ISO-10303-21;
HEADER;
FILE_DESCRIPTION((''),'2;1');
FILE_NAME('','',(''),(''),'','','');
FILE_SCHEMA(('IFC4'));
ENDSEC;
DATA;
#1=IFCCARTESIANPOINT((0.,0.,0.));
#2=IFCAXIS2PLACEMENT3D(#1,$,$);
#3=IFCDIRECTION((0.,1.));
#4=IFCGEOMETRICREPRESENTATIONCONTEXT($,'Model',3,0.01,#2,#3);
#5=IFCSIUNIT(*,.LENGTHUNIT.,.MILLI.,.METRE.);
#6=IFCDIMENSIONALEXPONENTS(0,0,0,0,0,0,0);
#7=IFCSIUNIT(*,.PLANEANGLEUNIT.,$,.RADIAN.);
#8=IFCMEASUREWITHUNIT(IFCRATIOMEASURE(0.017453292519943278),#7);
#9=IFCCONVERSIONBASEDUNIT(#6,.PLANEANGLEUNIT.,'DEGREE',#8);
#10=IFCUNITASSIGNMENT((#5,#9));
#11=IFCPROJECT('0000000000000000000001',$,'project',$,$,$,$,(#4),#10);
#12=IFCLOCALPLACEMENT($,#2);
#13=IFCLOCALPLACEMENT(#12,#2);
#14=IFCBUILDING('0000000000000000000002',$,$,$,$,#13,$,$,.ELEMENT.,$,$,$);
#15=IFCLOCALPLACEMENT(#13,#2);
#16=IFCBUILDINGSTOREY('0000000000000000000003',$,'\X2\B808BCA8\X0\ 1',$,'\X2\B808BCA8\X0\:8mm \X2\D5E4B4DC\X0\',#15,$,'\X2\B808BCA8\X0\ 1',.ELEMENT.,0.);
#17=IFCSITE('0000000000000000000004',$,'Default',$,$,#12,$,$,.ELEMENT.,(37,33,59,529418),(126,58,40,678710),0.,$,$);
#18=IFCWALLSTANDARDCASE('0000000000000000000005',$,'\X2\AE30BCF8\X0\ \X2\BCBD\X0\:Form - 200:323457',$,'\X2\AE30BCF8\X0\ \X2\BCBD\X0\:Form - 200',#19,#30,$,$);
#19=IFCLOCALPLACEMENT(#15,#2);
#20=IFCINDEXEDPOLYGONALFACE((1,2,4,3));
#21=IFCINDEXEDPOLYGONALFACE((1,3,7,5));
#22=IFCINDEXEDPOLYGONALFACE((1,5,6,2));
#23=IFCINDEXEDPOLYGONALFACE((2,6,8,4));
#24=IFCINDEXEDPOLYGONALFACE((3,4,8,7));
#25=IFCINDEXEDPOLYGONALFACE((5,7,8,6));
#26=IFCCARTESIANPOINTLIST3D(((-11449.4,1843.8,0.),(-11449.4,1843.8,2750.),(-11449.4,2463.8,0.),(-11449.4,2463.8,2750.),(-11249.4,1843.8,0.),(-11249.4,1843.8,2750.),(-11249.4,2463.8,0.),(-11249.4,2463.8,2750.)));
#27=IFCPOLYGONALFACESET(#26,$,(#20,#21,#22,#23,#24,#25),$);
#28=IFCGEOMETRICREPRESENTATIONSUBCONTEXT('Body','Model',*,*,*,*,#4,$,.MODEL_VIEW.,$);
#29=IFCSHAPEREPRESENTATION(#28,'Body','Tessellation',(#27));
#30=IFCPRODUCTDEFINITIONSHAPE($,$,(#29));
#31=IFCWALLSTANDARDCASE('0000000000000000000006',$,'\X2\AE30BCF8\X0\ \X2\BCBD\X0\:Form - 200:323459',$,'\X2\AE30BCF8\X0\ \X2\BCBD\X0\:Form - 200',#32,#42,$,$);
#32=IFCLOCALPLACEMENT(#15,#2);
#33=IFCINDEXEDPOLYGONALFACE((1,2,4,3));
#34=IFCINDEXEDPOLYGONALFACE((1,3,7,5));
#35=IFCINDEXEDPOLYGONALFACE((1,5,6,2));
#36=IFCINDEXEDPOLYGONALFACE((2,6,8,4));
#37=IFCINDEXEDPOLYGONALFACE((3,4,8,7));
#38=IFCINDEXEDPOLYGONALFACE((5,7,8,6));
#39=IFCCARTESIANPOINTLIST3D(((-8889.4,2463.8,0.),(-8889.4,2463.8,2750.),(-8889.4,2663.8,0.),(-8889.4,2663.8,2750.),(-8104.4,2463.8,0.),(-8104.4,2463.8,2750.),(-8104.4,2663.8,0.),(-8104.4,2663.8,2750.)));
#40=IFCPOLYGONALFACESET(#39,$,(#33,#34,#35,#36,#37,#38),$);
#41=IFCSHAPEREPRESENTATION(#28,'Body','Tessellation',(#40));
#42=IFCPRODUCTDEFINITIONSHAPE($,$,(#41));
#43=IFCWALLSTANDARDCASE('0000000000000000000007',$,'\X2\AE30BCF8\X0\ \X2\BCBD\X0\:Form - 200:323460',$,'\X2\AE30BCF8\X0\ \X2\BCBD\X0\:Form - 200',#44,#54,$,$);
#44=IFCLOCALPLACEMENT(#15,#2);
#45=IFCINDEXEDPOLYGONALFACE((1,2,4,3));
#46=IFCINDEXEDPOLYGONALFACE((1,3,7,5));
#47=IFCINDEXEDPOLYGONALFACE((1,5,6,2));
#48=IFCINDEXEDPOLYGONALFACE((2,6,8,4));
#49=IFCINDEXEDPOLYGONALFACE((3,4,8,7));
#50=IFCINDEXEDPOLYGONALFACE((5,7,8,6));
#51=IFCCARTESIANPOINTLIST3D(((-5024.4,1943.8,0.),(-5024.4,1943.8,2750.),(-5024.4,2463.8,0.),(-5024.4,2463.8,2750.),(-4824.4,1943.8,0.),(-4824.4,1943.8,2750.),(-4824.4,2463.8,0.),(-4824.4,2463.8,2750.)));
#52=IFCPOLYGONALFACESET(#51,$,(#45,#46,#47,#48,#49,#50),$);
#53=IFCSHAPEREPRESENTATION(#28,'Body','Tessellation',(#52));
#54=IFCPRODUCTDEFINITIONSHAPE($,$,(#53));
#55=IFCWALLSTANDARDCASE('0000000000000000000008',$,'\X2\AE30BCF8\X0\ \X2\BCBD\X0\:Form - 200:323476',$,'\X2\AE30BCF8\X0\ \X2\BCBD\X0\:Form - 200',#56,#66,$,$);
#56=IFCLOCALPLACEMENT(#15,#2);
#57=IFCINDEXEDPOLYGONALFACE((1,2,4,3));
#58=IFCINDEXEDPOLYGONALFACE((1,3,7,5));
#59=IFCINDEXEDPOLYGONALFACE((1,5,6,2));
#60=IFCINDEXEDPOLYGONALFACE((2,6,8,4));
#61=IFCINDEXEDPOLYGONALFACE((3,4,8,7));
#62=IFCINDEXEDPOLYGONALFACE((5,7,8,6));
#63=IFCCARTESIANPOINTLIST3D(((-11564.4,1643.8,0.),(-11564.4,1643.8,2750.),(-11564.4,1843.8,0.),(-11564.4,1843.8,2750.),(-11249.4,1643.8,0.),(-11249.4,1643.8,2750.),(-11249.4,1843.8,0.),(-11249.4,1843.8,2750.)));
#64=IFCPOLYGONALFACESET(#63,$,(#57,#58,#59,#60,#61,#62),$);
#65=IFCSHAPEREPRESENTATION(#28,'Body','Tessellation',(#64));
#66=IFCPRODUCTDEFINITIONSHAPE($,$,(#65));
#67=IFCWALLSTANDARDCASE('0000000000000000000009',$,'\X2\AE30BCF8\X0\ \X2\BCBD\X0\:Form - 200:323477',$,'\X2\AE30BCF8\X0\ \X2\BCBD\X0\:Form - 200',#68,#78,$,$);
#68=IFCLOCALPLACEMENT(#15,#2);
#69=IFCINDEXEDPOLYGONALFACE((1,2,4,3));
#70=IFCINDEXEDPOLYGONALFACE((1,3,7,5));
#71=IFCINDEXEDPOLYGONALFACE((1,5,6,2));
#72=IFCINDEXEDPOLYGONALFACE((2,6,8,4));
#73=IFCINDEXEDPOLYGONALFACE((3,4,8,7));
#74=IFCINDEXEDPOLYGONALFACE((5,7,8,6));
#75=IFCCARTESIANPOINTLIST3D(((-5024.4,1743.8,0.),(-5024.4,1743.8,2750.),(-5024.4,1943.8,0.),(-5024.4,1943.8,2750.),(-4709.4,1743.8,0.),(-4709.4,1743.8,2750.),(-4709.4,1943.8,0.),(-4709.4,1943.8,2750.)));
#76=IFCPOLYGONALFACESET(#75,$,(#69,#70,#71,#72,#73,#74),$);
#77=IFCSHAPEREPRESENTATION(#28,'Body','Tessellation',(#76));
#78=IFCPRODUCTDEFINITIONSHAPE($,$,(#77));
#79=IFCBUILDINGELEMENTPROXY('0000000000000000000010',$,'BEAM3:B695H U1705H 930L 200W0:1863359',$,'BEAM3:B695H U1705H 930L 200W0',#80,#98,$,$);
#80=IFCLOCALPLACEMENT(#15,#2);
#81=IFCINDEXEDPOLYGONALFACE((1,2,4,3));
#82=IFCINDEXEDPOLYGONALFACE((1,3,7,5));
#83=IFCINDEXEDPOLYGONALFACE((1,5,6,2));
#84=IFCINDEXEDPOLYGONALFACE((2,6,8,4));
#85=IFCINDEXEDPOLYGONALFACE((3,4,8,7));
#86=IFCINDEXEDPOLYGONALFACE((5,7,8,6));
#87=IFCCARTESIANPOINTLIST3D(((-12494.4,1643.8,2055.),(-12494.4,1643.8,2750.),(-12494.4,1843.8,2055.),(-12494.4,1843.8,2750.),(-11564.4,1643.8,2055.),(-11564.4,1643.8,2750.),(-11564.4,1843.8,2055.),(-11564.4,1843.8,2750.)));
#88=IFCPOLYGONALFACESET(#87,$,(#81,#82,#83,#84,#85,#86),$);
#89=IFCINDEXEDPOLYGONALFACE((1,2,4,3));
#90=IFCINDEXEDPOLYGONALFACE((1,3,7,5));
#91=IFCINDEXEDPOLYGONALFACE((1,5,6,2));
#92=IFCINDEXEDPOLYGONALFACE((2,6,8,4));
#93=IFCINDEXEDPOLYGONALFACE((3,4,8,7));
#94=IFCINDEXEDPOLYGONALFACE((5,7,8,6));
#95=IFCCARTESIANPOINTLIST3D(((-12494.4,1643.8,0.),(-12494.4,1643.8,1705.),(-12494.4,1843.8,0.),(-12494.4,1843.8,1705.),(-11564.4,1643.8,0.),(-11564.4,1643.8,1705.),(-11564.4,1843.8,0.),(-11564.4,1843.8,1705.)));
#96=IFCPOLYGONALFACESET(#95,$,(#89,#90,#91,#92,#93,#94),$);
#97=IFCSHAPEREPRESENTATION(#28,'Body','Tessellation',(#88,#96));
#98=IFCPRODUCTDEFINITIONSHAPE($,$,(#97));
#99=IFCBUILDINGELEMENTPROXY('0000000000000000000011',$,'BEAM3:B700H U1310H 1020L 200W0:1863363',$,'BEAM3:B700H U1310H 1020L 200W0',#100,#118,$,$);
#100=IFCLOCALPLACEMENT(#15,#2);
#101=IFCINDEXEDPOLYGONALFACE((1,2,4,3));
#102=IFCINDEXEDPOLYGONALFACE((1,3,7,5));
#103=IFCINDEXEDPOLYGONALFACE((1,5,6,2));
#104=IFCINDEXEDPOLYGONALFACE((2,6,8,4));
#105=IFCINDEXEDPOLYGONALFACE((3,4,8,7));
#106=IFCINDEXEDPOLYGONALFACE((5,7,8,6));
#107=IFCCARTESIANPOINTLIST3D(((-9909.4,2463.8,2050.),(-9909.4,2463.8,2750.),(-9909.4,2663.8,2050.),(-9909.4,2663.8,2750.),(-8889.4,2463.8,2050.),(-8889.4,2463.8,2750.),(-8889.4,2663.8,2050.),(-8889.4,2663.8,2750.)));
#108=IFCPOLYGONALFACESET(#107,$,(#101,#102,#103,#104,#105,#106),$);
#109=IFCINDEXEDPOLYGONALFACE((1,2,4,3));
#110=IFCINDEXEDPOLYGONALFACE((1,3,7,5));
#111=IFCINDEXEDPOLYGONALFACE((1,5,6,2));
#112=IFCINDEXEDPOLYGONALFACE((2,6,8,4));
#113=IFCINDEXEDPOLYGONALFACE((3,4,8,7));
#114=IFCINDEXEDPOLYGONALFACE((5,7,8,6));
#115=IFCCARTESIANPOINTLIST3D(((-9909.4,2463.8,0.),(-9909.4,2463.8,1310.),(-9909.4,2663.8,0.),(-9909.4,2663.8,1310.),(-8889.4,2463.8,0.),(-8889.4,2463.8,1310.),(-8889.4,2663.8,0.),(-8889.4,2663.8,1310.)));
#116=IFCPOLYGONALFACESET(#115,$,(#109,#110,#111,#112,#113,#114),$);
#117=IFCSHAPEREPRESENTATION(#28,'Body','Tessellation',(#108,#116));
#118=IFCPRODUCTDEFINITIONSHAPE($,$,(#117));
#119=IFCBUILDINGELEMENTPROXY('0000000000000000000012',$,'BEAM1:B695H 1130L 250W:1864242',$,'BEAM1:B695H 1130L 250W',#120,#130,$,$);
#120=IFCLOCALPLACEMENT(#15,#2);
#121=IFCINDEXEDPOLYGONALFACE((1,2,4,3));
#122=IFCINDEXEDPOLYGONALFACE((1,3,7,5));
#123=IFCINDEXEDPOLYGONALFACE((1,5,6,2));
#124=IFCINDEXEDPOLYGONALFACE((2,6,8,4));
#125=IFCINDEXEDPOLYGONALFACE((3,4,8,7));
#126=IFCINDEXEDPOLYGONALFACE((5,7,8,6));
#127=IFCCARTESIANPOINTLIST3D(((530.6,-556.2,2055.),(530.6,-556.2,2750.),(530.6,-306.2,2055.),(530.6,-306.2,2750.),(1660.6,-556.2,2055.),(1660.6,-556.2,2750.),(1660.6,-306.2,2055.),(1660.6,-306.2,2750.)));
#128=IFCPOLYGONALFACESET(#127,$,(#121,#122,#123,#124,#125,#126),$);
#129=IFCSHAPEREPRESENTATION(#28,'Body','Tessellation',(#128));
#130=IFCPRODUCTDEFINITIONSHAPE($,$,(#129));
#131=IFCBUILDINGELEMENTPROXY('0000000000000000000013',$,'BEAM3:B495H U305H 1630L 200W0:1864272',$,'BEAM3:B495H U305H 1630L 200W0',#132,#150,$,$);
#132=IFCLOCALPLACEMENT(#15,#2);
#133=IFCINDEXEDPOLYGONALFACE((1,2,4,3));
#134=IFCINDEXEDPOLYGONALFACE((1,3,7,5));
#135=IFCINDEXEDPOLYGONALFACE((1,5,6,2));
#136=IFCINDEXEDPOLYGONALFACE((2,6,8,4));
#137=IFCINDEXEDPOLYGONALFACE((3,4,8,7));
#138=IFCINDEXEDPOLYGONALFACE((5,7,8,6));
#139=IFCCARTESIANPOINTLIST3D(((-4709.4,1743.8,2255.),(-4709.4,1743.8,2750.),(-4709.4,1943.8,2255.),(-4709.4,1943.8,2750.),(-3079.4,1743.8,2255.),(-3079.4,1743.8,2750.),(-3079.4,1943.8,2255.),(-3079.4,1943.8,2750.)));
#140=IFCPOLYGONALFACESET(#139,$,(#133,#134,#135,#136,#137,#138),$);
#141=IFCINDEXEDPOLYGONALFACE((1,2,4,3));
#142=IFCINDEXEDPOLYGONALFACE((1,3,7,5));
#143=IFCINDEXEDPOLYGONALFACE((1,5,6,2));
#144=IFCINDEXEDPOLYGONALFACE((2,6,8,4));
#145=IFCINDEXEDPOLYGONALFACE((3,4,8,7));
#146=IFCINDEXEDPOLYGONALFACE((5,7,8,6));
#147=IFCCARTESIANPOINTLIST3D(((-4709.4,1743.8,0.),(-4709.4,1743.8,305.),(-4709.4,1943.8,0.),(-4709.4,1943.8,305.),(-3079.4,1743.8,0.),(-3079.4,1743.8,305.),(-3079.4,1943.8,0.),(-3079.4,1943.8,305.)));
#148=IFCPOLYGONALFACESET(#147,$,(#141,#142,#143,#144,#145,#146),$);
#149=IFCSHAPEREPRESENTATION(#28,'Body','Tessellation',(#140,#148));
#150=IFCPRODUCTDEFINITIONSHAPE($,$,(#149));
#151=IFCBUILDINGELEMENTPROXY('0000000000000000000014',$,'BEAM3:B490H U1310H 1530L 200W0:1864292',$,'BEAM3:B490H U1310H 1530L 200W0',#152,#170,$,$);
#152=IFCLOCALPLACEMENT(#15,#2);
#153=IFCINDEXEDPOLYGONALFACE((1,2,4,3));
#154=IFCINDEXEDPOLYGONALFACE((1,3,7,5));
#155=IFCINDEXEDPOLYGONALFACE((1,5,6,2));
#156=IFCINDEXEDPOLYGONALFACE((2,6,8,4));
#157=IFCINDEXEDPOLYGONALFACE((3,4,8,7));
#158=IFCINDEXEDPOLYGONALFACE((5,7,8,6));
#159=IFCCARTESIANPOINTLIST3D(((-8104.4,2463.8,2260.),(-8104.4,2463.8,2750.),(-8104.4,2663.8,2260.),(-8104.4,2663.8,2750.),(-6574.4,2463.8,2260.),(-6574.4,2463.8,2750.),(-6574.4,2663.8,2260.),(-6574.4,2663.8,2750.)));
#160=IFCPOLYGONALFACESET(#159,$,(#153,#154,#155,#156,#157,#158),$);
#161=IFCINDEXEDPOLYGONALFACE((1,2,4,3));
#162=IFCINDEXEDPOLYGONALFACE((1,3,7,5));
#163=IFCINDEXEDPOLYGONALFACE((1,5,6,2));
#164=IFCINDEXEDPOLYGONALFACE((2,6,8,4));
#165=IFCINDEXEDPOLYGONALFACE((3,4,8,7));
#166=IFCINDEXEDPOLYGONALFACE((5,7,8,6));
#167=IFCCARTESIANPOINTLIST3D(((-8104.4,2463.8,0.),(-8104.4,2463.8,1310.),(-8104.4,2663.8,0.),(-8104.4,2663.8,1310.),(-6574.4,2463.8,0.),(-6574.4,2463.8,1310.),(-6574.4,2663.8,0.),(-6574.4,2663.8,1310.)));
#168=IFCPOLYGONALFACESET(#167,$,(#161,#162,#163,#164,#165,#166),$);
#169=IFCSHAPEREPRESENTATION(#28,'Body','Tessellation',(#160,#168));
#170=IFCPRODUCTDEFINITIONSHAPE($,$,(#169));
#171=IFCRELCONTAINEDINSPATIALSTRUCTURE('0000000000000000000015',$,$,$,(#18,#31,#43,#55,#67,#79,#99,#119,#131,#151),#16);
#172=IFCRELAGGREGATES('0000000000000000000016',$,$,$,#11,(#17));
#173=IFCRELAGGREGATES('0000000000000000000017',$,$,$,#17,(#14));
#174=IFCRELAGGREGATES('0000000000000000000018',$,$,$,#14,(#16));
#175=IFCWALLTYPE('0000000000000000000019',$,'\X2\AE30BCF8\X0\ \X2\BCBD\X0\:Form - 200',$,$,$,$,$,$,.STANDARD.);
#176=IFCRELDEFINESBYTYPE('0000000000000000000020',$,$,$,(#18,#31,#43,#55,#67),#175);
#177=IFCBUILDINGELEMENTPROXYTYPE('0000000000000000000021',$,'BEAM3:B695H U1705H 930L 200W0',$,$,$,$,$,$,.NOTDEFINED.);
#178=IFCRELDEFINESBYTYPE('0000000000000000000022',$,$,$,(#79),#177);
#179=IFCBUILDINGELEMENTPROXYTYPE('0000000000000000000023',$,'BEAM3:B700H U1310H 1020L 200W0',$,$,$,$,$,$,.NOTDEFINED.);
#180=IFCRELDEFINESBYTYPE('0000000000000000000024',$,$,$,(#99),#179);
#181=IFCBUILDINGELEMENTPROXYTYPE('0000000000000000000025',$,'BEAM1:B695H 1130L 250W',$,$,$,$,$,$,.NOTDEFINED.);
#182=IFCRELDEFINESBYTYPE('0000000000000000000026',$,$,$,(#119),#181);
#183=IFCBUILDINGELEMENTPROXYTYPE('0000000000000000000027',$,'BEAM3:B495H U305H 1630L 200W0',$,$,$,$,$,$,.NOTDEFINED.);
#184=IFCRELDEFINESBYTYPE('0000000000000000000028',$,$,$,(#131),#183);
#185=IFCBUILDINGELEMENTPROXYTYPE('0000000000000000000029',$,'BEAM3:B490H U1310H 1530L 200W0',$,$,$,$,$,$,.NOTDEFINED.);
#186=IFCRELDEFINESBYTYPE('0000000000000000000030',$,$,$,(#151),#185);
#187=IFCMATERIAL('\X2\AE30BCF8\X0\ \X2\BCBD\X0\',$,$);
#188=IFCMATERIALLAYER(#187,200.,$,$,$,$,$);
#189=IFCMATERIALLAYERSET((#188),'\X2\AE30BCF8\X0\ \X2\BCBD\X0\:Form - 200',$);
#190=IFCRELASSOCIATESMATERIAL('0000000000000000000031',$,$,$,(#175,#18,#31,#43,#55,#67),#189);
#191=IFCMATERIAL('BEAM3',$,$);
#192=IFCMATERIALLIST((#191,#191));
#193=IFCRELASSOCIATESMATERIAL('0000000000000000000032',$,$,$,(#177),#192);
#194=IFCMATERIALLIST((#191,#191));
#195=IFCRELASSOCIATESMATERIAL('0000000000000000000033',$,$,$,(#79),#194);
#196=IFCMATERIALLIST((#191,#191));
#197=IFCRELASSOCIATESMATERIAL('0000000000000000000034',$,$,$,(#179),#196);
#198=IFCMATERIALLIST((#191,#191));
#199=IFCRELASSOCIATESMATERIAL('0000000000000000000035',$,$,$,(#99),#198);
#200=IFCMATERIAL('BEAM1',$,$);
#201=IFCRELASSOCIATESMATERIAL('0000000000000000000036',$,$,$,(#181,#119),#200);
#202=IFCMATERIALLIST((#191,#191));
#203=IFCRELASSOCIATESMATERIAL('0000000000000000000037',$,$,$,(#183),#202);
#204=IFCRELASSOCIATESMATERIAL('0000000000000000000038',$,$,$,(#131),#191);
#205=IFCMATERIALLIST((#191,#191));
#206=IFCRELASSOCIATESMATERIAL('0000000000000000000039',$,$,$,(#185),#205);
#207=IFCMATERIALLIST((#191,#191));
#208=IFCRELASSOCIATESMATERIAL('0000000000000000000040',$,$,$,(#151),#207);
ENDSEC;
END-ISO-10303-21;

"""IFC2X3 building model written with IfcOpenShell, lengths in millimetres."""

from ifc_helpers import new_model, entity, si_unit, converted_unit, direction, frame, frame_2d, origin, origin_2d_with_axis, place, context, subcontext, project, spatial, rectangle, extrude, source, transform, mapped, material, material_list, layer, layer_set, layer_usage, type_object, type_shapes, element, save


model = new_model("IFC2X3")

# Units and contexts
model_context = context("Model", 3, precision=0.01, world=origin(), true_north=direction((0.0, 1.0)))
body_context = subcontext(model_context, "Body", "Model", "MODEL_VIEW")
ifc_project = project(units=[si_unit("LENGTHUNIT", "METRE", prefix="MILLI"), converted_unit("PLANEANGLEUNIT", "DEGREE", entity("IfcRatioMeasure", 0.017453292519943278), si_unit("PLANEANGLEUNIT", "RADIAN"), dimensions=[0, 0, 0, 0, 0, 0, 0])], contexts=[model_context])

# Site, building, storey
site_placement = place(None, origin())
site = spatial("IfcSite", under=ifc_project, at=site_placement, Name="Default", CompositionType="ELEMENT", RefLatitude=(37, 33, 59, 529418), RefLongitude=(126, 58, 40, 678710), RefElevation=0.0)
building_placement = place(site_placement, origin())
building = spatial("IfcBuilding", under=site, at=building_placement, CompositionType="ELEMENT")
storey_placement = place(building_placement, origin())
storey = spatial("IfcBuildingStorey", under=building, at=storey_placement, Name="레벨 1", ObjectType="레벨:8mm 헤드", LongName="레벨 1", CompositionType="ELEMENT", Elevation=0.0)

# Walls
ifc_material_1 = material(Name="기본 벽")
ifc_layer_1 = layer(ifc_material_1, 200.0)
ifc_layer_set_1 = layer_set([ifc_layer_1], Name="기본 벽:Form - 200")
wall_type_1 = type_object("IfcWallType", Name="기본 벽:Form - 200", PredefinedType="STANDARD", material=ifc_layer_set_1)
ifc_layer_usage_1 = layer_usage(ifc_layer_set_1, "AXIS2", "POSITIVE", -100.0)
wall_1_placement = place(storey_placement, frame((-11349.4, 1843.8, 0.0), z_axis=(0.0, 0.0, 1.0), x_axis=(0.0, 1.0, 0.0)))
element("IfcWallStandardCase", 1, at=wall_1_placement, inside=storey, type_object=wall_type_1, material=ifc_layer_usage_1, Name="기본 벽:Form - 200:323457", ObjectType="기본 벽:Form - 200", context=body_context, shape_type="SweptSolid", body=[
    extrude(rectangle(XDim=620.0, YDim=200.0, at=frame_2d((310.0, 0.0), x_axis=(-1.0, 0.0))), origin(), (0.0, 0.0, 1.0), 2750.0),
])
ifc_layer_usage_2 = layer_usage(ifc_layer_set_1, "AXIS2", "POSITIVE", -100.0)
wall_2_placement = place(storey_placement, frame((-8889.4, 2563.8, 0.0)))
element("IfcWallStandardCase", 2, at=wall_2_placement, inside=storey, type_object=wall_type_1, material=ifc_layer_usage_2, Name="기본 벽:Form - 200:323459", ObjectType="기본 벽:Form - 200", context=body_context, shape_type="SweptSolid", body=[
    extrude(rectangle(XDim=785.0, YDim=200.0, at=frame_2d((392.5, 0.0), x_axis=(-1.0, 0.0))), origin(), (0.0, 0.0, 1.0), 2750.0),
])
ifc_layer_usage_3 = layer_usage(ifc_layer_set_1, "AXIS2", "POSITIVE", -100.0)
wall_3_placement = place(storey_placement, frame((-4924.4, 2463.8, 0.0), z_axis=(0.0, 0.0, 1.0), x_axis=(0.0, -1.0, 0.0)))
element("IfcWallStandardCase", 3, at=wall_3_placement, inside=storey, type_object=wall_type_1, material=ifc_layer_usage_3, Name="기본 벽:Form - 200:323460", ObjectType="기본 벽:Form - 200", context=body_context, shape_type="SweptSolid", body=[
    extrude(rectangle(XDim=520.0, YDim=200.0, at=frame_2d((260.0, 0.0), x_axis=(-1.0, 0.0))), origin(), (0.0, 0.0, 1.0), 2750.0),
])
ifc_layer_usage_4 = layer_usage(ifc_layer_set_1, "AXIS2", "POSITIVE", -100.0)
wall_4_placement = place(storey_placement, frame((-11564.4, 1743.8, 0.0)))
element("IfcWallStandardCase", 4, at=wall_4_placement, inside=storey, type_object=wall_type_1, material=ifc_layer_usage_4, Name="기본 벽:Form - 200:323476", ObjectType="기본 벽:Form - 200", context=body_context, shape_type="SweptSolid", body=[
    extrude(rectangle(XDim=315.0, YDim=200.0, at=frame_2d((157.5, 0.0), x_axis=(-1.0, 0.0))), origin(), (0.0, 0.0, 1.0), 2750.0),
])
ifc_layer_usage_5 = layer_usage(ifc_layer_set_1, "AXIS2", "POSITIVE", -100.0)
wall_5_placement = place(storey_placement, frame((-4709.4, 1843.8, 0.0), z_axis=(0.0, 0.0, 1.0), x_axis=(-1.0, 0.0, 0.0)))
element("IfcWallStandardCase", 5, at=wall_5_placement, inside=storey, type_object=wall_type_1, material=ifc_layer_usage_5, Name="기본 벽:Form - 200:323477", ObjectType="기본 벽:Form - 200", context=body_context, shape_type="SweptSolid", body=[
    extrude(rectangle(XDim=315.0, YDim=200.0, at=frame_2d((157.5, 0.0), x_axis=(-1.0, 0.0))), origin(), (0.0, 0.0, 1.0), 2750.0),
])

# Building element proxies
ifc_material_2 = material(Name="BEAM3")
ifc_material_list_1 = material_list([ifc_material_2, ifc_material_2])
ifc_material_list_2 = material_list([ifc_material_2, ifc_material_2])
building_element_proxy_type_1 = type_object("IfcBuildingElementProxyType", Name="BEAM3:B695H U1705H 930L 200W0", PredefinedType="NOTDEFINED", material=ifc_material_list_2)
shared_shape_1 = source(origin(), body_context, "Body", "SweptSolid", [
    extrude(rectangle(XDim=930.0, YDim=200.0, at=origin_2d_with_axis()), frame((465.0, -100.0, 2055.0)), (0.0, 0.0, 1.0), 695.0),
    extrude(rectangle(XDim=930.0, YDim=200.0, at=origin_2d_with_axis()), frame((465.0, -100.0, 0.0)), (0.0, 0.0, 1.0), 1705.0),
])
type_shapes(building_element_proxy_type_1, [shared_shape_1])
proxy_1_placement = place(storey_placement, frame((-12494.4, 1843.8, 0.0)))
element("IfcBuildingElementProxy", 6, at=proxy_1_placement, inside=storey, type_object=building_element_proxy_type_1, material=ifc_material_list_1, Name="BEAM3:B695H U1705H 930L 200W0:1863359", ObjectType="BEAM3:B695H U1705H 930L 200W0", context=body_context, shape_type="MappedRepresentation", body=[
    mapped(shared_shape_1, transform((0.0, 0.0, 0.0), scale=1.0)),
])
ifc_material_list_3 = material_list([ifc_material_2, ifc_material_2])
ifc_material_list_4 = material_list([ifc_material_2, ifc_material_2])
building_element_proxy_type_2 = type_object("IfcBuildingElementProxyType", Name="BEAM3:B700H U1310H 1020L 200W0", PredefinedType="NOTDEFINED", material=ifc_material_list_4)
shared_shape_2 = source(origin(), body_context, "Body", "SweptSolid", [
    extrude(rectangle(XDim=1020.0, YDim=200.0, at=origin_2d_with_axis()), frame((510.0, -100.0, 2050.0)), (0.0, 0.0, 1.0), 700.0),
    extrude(rectangle(XDim=1020.0, YDim=200.0, at=origin_2d_with_axis()), frame((510.0, -100.0, 0.0)), (0.0, 0.0, 1.0), 1310.0),
])
type_shapes(building_element_proxy_type_2, [shared_shape_2])
proxy_2_placement = place(storey_placement, frame((-9909.4, 2663.8, 0.0)))
element("IfcBuildingElementProxy", 7, at=proxy_2_placement, inside=storey, type_object=building_element_proxy_type_2, material=ifc_material_list_3, Name="BEAM3:B700H U1310H 1020L 200W0:1863363", ObjectType="BEAM3:B700H U1310H 1020L 200W0", context=body_context, shape_type="MappedRepresentation", body=[
    mapped(shared_shape_2, transform((0.0, 0.0, 0.0), scale=1.0)),
])
ifc_material_3 = material(Name="BEAM1")
building_element_proxy_type_3 = type_object("IfcBuildingElementProxyType", Name="BEAM1:B695H 1130L 250W", PredefinedType="NOTDEFINED", material=ifc_material_3)
shared_shape_3 = source(origin(), body_context, "Body", "SweptSolid", [
    extrude(rectangle(XDim=1130.0, YDim=250.0, at=origin_2d_with_axis()), frame((565.0, -125.0, -695.0)), (0.0, 0.0, 1.0), 695.0),
])
type_shapes(building_element_proxy_type_3, [shared_shape_3])
proxy_3_placement = place(storey_placement, frame((530.6, -306.2, 2750.0)))
element("IfcBuildingElementProxy", 8, at=proxy_3_placement, inside=storey, type_object=building_element_proxy_type_3, material=ifc_material_3, Name="BEAM1:B695H 1130L 250W:1864242", ObjectType="BEAM1:B695H 1130L 250W", context=body_context, shape_type="MappedRepresentation", body=[
    mapped(shared_shape_3, transform((0.0, 0.0, 0.0), scale=1.0)),
])
ifc_material_list_5 = material_list([ifc_material_2, ifc_material_2])
building_element_proxy_type_4 = type_object("IfcBuildingElementProxyType", Name="BEAM3:B495H U305H 1630L 200W0", PredefinedType="NOTDEFINED", material=ifc_material_list_5)
shared_shape_4 = source(origin(), body_context, "Body", "SweptSolid", [
    extrude(rectangle(XDim=1630.0, YDim=200.0, at=origin_2d_with_axis()), frame((815.0, -100.0, 2255.0)), (0.0, 0.0, 1.0), 495.0),
    extrude(rectangle(XDim=1630.0, YDim=200.0, at=origin_2d_with_axis()), frame((815.0, -100.0, 0.0)), (0.0, 0.0, 1.0), 305.0),
])
type_shapes(building_element_proxy_type_4, [shared_shape_4])
proxy_4_placement = place(storey_placement, frame((-3079.4, 1743.8, 0.0), z_axis=(0.0, 0.0, 1.0), x_axis=(-1.0, 0.0, 0.0)))
element("IfcBuildingElementProxy", 9, at=proxy_4_placement, inside=storey, type_object=building_element_proxy_type_4, material=ifc_material_2, Name="BEAM3:B495H U305H 1630L 200W0:1864272", ObjectType="BEAM3:B495H U305H 1630L 200W0", context=body_context, shape_type="MappedRepresentation", body=[
    mapped(shared_shape_4, transform((0.0, 0.0, 0.0), scale=1.0)),
])
ifc_material_list_6 = material_list([ifc_material_2, ifc_material_2])
ifc_material_list_7 = material_list([ifc_material_2, ifc_material_2])
building_element_proxy_type_5 = type_object("IfcBuildingElementProxyType", Name="BEAM3:B490H U1310H 1530L 200W0", PredefinedType="NOTDEFINED", material=ifc_material_list_7)
shared_shape_5 = source(origin(), body_context, "Body", "SweptSolid", [
    extrude(rectangle(XDim=1530.0, YDim=200.0, at=origin_2d_with_axis()), frame((765.0, -100.0, 2260.0)), (0.0, 0.0, 1.0), 490.0),
    extrude(rectangle(XDim=1530.0, YDim=200.0, at=origin_2d_with_axis()), frame((765.0, -100.0, 0.0)), (0.0, 0.0, 1.0), 1310.0),
])
type_shapes(building_element_proxy_type_5, [shared_shape_5])
proxy_5_placement = place(storey_placement, frame((-8104.4, 2663.8, 0.0)))
element("IfcBuildingElementProxy", 10, at=proxy_5_placement, inside=storey, type_object=building_element_proxy_type_5, material=ifc_material_list_6, Name="BEAM3:B490H U1310H 1530L 200W0:1864292", ObjectType="BEAM3:B490H U1310H 1530L 200W0", context=body_context, shape_type="MappedRepresentation", body=[
    mapped(shared_shape_5, transform((0.0, 0.0, 0.0), scale=1.0)),
])

save(model, "model.ifc")
